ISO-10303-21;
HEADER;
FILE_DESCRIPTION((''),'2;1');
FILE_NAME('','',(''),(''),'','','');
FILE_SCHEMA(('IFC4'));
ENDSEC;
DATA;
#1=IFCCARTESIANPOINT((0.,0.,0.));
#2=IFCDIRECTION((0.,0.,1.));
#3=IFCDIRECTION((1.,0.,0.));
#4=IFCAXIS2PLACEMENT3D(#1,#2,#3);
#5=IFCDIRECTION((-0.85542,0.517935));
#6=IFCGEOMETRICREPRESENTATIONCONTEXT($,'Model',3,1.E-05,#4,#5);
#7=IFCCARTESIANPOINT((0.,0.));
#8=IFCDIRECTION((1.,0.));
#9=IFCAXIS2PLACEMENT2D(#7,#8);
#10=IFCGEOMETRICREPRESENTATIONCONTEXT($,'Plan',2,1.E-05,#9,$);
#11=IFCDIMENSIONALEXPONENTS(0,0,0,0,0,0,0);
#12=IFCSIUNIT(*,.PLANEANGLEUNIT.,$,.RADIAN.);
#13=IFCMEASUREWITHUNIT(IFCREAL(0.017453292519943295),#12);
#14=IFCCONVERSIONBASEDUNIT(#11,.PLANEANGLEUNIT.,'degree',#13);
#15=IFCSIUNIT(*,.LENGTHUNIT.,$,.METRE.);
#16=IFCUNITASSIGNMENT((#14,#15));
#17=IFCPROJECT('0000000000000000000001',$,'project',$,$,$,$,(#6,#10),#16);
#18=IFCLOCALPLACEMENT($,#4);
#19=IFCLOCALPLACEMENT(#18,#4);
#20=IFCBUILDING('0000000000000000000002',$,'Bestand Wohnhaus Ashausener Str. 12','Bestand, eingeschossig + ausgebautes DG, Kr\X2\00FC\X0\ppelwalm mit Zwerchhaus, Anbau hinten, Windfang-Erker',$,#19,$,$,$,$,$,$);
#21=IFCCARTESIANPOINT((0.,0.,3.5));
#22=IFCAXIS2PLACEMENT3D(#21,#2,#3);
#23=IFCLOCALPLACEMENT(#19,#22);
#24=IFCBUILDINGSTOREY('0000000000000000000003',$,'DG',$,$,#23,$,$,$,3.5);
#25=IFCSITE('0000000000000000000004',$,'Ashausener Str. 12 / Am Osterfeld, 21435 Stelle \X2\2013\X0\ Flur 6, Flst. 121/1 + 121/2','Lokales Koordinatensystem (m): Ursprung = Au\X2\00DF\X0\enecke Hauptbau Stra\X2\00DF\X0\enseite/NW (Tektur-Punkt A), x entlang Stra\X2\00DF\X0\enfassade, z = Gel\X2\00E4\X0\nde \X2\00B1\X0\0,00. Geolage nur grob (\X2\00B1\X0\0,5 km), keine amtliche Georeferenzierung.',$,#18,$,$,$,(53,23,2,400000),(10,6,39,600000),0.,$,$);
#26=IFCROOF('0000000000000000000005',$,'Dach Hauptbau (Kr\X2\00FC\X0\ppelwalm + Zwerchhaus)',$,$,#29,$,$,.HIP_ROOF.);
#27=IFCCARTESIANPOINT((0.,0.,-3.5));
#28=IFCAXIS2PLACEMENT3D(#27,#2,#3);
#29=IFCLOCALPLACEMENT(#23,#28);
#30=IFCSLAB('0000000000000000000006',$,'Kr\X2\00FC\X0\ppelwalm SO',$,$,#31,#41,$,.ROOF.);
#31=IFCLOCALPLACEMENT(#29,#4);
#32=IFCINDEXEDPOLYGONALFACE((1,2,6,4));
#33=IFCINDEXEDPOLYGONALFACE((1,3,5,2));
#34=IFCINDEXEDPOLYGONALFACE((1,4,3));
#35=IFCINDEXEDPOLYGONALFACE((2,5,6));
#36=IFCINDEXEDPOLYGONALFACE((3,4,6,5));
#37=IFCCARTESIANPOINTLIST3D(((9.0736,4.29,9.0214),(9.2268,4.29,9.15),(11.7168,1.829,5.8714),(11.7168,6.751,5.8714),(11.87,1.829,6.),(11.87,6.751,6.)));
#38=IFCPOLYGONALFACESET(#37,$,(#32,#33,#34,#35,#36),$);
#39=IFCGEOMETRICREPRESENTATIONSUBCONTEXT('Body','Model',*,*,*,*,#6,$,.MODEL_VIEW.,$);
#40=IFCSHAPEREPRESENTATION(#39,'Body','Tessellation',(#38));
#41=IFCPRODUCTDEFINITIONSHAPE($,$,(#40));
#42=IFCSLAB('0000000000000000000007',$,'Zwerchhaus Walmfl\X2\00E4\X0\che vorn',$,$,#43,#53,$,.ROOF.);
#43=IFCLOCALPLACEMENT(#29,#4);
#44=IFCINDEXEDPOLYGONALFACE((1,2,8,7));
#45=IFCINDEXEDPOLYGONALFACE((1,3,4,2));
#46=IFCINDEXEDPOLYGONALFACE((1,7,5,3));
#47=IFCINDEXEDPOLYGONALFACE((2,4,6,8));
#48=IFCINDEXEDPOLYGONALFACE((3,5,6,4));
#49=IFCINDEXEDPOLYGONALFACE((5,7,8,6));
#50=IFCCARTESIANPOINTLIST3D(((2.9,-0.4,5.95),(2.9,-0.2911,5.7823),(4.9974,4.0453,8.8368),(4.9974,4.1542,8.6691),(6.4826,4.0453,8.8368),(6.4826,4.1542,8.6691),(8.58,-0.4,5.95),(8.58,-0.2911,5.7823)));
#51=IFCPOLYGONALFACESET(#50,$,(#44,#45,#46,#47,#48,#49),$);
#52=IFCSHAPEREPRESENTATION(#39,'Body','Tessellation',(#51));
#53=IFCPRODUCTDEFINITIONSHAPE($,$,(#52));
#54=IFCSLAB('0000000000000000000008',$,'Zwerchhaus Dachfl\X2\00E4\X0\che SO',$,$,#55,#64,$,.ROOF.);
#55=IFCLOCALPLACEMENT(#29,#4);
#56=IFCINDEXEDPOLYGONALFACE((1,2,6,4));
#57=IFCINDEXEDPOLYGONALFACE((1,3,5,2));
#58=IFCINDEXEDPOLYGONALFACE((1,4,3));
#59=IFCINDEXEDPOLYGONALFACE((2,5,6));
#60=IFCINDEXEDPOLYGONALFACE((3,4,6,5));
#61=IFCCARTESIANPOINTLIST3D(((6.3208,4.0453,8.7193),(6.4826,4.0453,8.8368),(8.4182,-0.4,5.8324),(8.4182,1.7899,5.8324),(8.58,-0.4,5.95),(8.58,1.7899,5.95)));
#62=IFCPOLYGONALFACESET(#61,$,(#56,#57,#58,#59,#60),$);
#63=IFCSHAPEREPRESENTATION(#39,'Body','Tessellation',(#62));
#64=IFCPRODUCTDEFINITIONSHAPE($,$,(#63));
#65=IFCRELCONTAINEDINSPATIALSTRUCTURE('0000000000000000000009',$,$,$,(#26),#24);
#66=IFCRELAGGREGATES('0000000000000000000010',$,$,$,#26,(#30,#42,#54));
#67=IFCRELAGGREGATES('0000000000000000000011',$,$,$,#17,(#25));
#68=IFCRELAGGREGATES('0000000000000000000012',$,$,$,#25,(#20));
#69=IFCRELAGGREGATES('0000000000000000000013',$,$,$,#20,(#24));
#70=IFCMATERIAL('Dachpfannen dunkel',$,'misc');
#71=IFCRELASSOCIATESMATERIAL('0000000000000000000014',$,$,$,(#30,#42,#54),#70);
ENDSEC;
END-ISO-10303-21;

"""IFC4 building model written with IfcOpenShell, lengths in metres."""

from ifc_helpers import new_model, entity, si_unit, converted_unit, direction, frame, origin_with_axes, origin_2d_with_axis, place, context, subcontext, project, spatial, polyline, outline, extrude, material, element, aggregate, save


model = new_model("IFC4")

# Units and contexts
model_context = context("Model", 3, precision=1e-05, world=origin_with_axes(), true_north=direction((-0.85542, 0.517935)))
plan_context = context("Plan", 2, precision=1e-05, world=origin_2d_with_axis())
body_context = subcontext(model_context, "Body", "Model", "MODEL_VIEW")
ifc_project = project(units=[converted_unit("PLANEANGLEUNIT", "degree", entity("IfcReal", 0.017453292519943295), si_unit("PLANEANGLEUNIT", "RADIAN"), dimensions=[0, 0, 0, 0, 0, 0, 0]), si_unit("LENGTHUNIT", "METRE")], contexts=[model_context, plan_context])

# Site, building, storey
site_placement = place(None, origin_with_axes())
site = spatial("IfcSite", under=ifc_project, at=site_placement, Name="Ashausener Str. 12 / Am Osterfeld, 21435 Stelle – Flur 6, Flst. 121/1 + 121/2", Description="Lokales Koordinatensystem (m): Ursprung = Außenecke Hauptbau Straßenseite/NW (Tektur-Punkt A), x entlang Straßenfassade, z = Gelände ±0,00. Geolage nur grob (±0,5 km), keine amtliche Georeferenzierung.", RefLatitude=(53, 23, 2, 400000), RefLongitude=(10, 6, 39, 600000), RefElevation=0.0)
building_placement = place(site_placement, origin_with_axes())
building = spatial("IfcBuilding", under=site, at=building_placement, Name="Bestand Wohnhaus Ashausener Str. 12", Description="Bestand, eingeschossig + ausgebautes DG, Krüppelwalm mit Zwerchhaus, Anbau hinten, Windfang-Erker")
storey_placement = place(building_placement, frame((0.0, 0.0, 3.5), z_axis=(0.0, 0.0, 1.0), x_axis=(1.0, 0.0, 0.0)))
storey = spatial("IfcBuildingStorey", under=building, at=storey_placement, Name="DG", Elevation=3.5)

# Roof, slabs
roof_placement = place(storey_placement, frame((0.0, 0.0, -3.5), z_axis=(0.0, 0.0, 1.0), x_axis=(1.0, 0.0, 0.0)))
roof = element("IfcRoof", 1, at=roof_placement, inside=storey, Name="Dach Hauptbau (Krüppelwalm + Zwerchhaus)", PredefinedType="HIP_ROOF")
ifc_material_1 = material(Name="Dachpfannen dunkel", Category="misc")
slab_1_placement = place(roof_placement, origin_with_axes())
slab_1 = element("IfcSlab", 2, at=slab_1_placement, material=ifc_material_1, Name="Krüppelwalm SO", PredefinedType="ROOF", context=body_context, shape_type="SweptSolid", body=[
    extrude(outline(polyline([(0.0, 0.0), (4.9221, 0.0), (2.4611, 4.112), (0.0, 0.0)])), frame((11.87, 1.829, 6.0), z_axis=(0.766045, 0.0, 0.642787), x_axis=(0.0, 1.0, 0.0)), (0.0, 0.0, -1.0), 0.2),
])
slab_2_placement = place(roof_placement, origin_with_axes())
slab_2 = element("IfcSlab", 3, at=slab_2_placement, material=ifc_material_1, Name="Zwerchhaus Walmfläche vorn", PredefinedType="ROOF", context=body_context, shape_type="SweptSolid", body=[
    extrude(outline(polyline([(0.0, 0.0), (5.68, 0.0), (3.5826, 5.3004), (2.0974, 5.3004), (0.0, 0.0)])), frame((2.9, -0.4, 5.95), z_axis=(0.0, -0.54464, 0.83867), x_axis=(1.0, 0.0, 0.0)), (0.0, 0.0, -1.0), 0.2),
])
slab_3_placement = place(roof_placement, origin_with_axes())
slab_3 = element("IfcSlab", 4, at=slab_3_placement, material=ifc_material_1, Name="Zwerchhaus Dachfläche SO", PredefinedType="ROOF", context=body_context, shape_type="SweptSolid", body=[
    extrude(outline(polyline([(0.0, 0.0), (2.1899, 0.0), (4.4453, 3.5683), (0.0, 0.0)])), frame((8.58, -0.4, 5.95), z_axis=(0.809018, 0.0, 0.587784), x_axis=(0.0, 1.0, 0.0)), (0.0, 0.0, -1.0), 0.2),
])
aggregate(roof, [slab_1, slab_2, slab_3])

save(model, "model.ifc")
